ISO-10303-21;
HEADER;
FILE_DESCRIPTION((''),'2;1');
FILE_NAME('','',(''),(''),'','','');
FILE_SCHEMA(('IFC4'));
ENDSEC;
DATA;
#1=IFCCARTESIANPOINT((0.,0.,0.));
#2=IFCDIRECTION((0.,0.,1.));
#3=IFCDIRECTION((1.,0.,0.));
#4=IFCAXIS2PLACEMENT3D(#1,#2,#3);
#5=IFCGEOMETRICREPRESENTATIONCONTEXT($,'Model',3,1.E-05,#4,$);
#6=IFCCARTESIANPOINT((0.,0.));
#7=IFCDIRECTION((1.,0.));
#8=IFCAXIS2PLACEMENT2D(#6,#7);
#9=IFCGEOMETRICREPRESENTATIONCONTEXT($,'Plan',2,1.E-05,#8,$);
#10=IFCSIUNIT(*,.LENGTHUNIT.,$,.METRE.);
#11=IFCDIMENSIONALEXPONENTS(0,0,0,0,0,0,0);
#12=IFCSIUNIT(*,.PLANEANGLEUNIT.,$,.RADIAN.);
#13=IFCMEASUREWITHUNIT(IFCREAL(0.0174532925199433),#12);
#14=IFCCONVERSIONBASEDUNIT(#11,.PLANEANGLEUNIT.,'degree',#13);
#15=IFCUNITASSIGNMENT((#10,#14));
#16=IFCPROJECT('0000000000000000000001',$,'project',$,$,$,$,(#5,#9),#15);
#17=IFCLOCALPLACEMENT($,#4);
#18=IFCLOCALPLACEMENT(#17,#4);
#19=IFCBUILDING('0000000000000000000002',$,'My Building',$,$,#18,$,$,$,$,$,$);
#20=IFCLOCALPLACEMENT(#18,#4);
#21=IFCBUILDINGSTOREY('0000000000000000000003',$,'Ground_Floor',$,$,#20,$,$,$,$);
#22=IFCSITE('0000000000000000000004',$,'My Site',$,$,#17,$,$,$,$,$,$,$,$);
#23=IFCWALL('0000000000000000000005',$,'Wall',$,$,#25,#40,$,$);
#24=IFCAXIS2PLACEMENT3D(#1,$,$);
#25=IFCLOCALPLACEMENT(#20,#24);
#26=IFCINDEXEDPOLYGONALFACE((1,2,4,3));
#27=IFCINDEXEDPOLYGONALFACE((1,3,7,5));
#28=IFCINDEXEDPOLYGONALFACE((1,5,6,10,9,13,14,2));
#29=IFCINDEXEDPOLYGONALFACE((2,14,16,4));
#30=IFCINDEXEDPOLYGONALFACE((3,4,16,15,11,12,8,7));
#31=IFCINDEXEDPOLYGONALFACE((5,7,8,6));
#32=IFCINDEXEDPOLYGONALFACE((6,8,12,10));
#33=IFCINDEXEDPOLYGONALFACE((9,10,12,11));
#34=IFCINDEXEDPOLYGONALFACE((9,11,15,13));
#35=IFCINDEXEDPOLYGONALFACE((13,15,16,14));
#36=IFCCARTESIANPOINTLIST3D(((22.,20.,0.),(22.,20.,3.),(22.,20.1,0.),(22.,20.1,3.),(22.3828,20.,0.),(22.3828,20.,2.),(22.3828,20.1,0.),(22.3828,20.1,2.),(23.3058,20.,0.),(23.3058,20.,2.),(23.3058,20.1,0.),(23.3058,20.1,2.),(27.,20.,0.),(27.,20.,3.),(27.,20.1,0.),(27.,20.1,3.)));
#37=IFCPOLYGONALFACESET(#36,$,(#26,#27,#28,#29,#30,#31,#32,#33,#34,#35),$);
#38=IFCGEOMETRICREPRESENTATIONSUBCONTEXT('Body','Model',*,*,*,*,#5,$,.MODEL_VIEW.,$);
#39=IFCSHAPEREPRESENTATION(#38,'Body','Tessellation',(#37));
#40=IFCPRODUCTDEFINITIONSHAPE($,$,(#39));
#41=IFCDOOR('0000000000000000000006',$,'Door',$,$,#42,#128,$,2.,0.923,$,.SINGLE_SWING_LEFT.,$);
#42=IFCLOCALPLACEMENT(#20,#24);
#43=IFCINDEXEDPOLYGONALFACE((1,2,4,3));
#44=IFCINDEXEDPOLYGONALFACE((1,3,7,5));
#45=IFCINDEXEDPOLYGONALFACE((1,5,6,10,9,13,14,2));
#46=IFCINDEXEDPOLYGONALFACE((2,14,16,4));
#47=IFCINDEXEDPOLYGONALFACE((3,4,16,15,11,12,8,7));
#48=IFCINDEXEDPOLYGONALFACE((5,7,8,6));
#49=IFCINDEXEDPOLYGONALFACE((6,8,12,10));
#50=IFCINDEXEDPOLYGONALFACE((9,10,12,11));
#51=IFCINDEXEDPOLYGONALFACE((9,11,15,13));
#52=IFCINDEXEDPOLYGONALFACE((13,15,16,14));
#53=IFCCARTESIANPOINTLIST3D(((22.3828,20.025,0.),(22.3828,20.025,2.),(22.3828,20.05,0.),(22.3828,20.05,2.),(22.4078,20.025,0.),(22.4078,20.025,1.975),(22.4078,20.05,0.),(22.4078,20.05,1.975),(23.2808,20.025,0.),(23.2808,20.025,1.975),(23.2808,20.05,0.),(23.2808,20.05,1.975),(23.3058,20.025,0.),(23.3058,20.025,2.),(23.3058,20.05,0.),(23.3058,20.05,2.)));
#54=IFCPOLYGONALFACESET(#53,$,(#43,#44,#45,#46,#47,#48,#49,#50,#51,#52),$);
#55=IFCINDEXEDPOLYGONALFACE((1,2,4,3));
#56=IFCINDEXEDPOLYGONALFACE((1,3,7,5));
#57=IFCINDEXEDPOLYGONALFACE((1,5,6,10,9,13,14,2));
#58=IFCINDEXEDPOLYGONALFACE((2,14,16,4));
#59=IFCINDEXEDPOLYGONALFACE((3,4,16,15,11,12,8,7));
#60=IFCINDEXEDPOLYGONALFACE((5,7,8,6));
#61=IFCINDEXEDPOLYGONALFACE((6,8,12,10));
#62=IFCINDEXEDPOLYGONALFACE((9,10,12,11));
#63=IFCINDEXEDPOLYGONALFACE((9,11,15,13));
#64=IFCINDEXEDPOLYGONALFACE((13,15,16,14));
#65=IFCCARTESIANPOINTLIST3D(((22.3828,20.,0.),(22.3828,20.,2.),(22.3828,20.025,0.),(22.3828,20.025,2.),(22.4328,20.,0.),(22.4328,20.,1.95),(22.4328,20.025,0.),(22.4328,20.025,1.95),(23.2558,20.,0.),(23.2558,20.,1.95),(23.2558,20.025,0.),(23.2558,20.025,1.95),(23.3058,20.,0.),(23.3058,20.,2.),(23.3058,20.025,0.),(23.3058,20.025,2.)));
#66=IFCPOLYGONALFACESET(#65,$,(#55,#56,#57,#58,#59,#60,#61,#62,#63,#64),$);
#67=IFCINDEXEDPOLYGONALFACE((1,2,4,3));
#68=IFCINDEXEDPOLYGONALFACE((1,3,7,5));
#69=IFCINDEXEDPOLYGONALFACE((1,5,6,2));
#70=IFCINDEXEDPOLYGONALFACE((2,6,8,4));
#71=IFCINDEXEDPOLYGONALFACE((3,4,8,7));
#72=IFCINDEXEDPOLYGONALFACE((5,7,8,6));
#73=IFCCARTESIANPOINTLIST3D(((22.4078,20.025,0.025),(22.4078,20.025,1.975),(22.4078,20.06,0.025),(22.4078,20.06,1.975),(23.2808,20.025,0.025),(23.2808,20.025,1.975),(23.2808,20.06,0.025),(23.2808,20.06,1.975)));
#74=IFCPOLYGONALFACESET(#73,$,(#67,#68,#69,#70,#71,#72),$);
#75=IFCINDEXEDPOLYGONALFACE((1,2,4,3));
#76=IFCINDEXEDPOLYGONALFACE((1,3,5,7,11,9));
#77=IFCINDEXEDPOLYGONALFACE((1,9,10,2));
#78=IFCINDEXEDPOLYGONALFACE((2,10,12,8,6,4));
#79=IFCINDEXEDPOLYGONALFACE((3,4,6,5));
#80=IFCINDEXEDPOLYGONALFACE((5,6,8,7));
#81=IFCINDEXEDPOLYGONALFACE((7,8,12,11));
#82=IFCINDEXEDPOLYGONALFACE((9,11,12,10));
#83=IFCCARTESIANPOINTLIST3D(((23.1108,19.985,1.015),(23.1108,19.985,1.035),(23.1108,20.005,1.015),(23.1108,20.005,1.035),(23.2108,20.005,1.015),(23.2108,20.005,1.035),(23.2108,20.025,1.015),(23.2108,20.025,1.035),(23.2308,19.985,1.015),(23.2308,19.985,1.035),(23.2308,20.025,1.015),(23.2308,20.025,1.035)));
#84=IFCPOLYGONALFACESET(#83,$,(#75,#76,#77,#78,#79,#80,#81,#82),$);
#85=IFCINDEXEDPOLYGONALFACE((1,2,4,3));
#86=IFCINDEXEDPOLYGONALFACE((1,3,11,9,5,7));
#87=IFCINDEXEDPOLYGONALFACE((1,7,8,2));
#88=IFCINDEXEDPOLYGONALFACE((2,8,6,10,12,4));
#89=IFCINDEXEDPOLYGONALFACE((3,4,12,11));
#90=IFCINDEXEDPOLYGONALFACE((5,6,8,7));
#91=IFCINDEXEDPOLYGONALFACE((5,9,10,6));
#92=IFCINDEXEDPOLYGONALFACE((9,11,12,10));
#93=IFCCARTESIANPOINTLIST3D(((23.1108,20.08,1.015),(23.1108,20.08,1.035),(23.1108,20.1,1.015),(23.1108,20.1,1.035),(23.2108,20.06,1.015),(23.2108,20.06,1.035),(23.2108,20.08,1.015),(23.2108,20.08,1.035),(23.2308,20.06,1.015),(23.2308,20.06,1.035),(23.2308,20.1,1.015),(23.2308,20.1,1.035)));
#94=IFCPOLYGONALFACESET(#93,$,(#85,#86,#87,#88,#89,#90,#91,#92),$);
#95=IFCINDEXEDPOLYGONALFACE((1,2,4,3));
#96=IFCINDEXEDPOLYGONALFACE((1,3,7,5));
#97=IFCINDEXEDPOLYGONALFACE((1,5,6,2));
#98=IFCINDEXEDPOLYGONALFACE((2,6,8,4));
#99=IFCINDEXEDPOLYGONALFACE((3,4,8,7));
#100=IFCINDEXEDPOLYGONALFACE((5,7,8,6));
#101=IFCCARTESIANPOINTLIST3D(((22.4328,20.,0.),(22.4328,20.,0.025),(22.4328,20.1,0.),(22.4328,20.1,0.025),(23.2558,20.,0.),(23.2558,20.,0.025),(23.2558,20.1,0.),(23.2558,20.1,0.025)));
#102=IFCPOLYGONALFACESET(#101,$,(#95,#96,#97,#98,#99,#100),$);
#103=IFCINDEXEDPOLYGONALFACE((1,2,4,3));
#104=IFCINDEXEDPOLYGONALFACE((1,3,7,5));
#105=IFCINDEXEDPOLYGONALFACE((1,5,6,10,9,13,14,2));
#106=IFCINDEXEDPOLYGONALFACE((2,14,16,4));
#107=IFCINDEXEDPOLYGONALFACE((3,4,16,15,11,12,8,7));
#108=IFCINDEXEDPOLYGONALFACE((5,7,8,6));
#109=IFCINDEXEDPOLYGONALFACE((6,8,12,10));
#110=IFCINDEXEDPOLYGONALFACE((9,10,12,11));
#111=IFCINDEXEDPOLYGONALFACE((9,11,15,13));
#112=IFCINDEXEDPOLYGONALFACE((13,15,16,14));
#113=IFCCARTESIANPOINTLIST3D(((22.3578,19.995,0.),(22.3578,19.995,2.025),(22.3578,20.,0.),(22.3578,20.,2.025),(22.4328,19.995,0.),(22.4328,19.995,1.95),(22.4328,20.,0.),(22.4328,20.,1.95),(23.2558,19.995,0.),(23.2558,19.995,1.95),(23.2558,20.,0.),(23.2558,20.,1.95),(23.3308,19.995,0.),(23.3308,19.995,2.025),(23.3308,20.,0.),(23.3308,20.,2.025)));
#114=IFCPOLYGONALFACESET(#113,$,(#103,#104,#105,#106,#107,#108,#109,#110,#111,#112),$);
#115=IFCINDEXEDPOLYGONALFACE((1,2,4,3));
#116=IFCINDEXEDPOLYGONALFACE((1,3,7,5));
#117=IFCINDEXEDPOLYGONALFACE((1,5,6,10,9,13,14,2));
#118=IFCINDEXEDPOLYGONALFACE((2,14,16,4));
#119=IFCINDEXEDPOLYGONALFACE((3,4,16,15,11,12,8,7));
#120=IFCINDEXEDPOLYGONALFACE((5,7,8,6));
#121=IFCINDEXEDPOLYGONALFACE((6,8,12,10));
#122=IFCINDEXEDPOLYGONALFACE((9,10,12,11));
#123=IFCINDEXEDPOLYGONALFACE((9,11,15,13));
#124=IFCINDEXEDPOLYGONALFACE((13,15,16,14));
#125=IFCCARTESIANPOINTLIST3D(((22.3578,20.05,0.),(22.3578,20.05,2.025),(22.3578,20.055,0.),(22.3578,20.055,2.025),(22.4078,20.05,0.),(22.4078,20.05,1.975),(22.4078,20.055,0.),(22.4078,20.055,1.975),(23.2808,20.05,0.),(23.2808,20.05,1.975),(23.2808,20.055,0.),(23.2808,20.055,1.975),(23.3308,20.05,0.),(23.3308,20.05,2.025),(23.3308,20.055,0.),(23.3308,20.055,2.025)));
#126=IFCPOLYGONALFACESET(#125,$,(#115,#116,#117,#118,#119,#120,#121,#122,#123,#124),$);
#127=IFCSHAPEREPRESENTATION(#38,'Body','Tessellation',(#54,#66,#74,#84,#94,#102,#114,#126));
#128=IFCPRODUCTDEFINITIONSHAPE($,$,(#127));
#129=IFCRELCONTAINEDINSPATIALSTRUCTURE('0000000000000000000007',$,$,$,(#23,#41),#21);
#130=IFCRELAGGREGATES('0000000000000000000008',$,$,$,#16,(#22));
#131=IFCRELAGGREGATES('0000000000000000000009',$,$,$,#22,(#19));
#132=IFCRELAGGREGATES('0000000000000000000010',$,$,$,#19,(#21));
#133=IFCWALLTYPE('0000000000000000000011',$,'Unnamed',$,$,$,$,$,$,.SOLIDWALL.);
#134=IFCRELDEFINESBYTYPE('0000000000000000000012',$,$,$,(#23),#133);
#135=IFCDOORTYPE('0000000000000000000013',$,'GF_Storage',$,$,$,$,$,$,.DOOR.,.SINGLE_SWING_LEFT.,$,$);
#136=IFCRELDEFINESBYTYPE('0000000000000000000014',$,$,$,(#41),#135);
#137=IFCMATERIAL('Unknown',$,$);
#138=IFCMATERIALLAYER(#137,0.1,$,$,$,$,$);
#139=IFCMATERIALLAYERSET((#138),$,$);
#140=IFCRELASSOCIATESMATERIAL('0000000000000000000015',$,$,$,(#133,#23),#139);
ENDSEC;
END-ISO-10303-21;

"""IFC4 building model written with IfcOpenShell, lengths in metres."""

from ifc_helpers import new_model, entity, si_unit, converted_unit, frame, origin_with_axes, origin_2d_with_axis, place, context, subcontext, project, spatial, line, indexed_curve, outline, extrude, shape, source, transform, mapped, material, layer, layer_set, layer_usage, type_object, type_shapes, element, fill, save


model = new_model("IFC4")

# Units and contexts
model_context = context("Model", 3, precision=1e-05, world=origin_with_axes())
plan_context = context("Plan", 2, precision=1e-05, world=origin_2d_with_axis())
body_context_1 = subcontext(model_context, "Body", "Model", "MODEL_VIEW")
body_context_2 = subcontext(plan_context, "Body", "Plan", "PLAN_VIEW")
ifc_project = project(units=[si_unit("LENGTHUNIT", "METRE"), converted_unit("PLANEANGLEUNIT", "degree", entity("IfcReal", 0.0174532925199433), si_unit("PLANEANGLEUNIT", "RADIAN"), dimensions=[0, 0, 0, 0, 0, 0, 0])], contexts=[model_context, plan_context])

# Site, building, storey
site_placement = place(None, origin_with_axes())
site = spatial("IfcSite", under=ifc_project, at=site_placement, Name="My Site")
building_placement = place(site_placement, origin_with_axes())
building = spatial("IfcBuilding", under=site, at=building_placement, Name="My Building")
storey_placement = place(building_placement, origin_with_axes())
storey = spatial("IfcBuildingStorey", under=building, at=storey_placement, Name="Ground_Floor")

# Shared definitions
ifc_material = material(Name="Unknown")
ifc_layer = layer(ifc_material, 0.1)
ifc_layer_set = layer_set([ifc_layer])
wall_type = type_object("IfcWallType", Name="Unnamed", PredefinedType="SOLIDWALL", material=ifc_layer_set)

# Wall, opening, door
shared_shape_1 = source(origin_with_axes(), body_context_1, "Body", "SweptSolid", [
    extrude(outline(indexed_curve([(0.0, 0.0), (0.923, 0.0), (0.923, 2.0), (0.0, 2.0)], segments=[line(1, 2, 3, 4, 1)])), frame((0.0, -0.6, 0.0), z_axis=(0.0, -1.0, 0.0), x_axis=(1.0, 0.0, 0.0)), (0.0, 0.0, -1.0), 1.2),
])
door_type_1 = type_object("IfcDoorType", Name="GF_Storage", OperationType="SINGLE_SWING_LEFT", PredefinedType="DOOR")
shared_shape_2 = source(origin_with_axes(), body_context_1, "Body", "SweptSolid", [
    extrude(outline(indexed_curve([(0.0, 0.0), (0.0, 2.0), (0.923, 2.0), (0.923, 0.0), (0.898, 0.0), (0.898, 1.975), (0.025, 1.975), (0.025, 0.0)], segments=[line(1, 2, 3, 4, 5, 6, 7, 8, 1)])), frame((0.0, 0.025, 0.0), z_axis=(0.0, -1.0, 0.0), x_axis=(1.0, 0.0, 0.0)), (0.0, 0.0, -1.0), 0.025),
    extrude(outline(indexed_curve([(0.0, 0.0), (0.0, 2.0), (0.923, 2.0), (0.923, 0.0), (0.873, 0.0), (0.873, 1.95), (0.05, 1.95), (0.05, 0.0)], segments=[line(1, 2, 3, 4, 5, 6, 7, 8, 1)])), frame((0.0, 0.0, 0.0), z_axis=(0.0, -1.0, 0.0), x_axis=(1.0, 0.0, 0.0)), (0.0, 0.0, -1.0), 0.025),
    extrude(outline(indexed_curve([(0.0, 0.0), (0.873, 0.0), (0.873, 0.035), (0.0, 0.035)], segments=[line(1, 2, 3, 4, 1)])), frame((0.025, 0.025, 0.025), z_axis=(0.0, 0.0, 1.0), x_axis=(1.0, 0.0, 0.0)), (0.0, 0.0, 1.0), 1.95),
    extrude(outline(indexed_curve([(0.0, 0.0), (0.0, -0.04), (-0.12, -0.04), (-0.12, -0.02), (-0.02, -0.02), (-0.02, 0.0)], segments=[line(1, 2, 3, 4, 5, 6, 1)])), frame((0.848, 0.025, 1.015), z_axis=(0.0, 0.0, 1.0), x_axis=(1.0, 0.0, 0.0)), (0.0, 0.0, 1.0), 0.02),
    extrude(outline(indexed_curve([(0.0, 0.0), (0.0, 0.04), (-0.12, 0.04), (-0.12, 0.02), (-0.02, 0.02), (-0.02, 0.0)], segments=[line(1, 2, 3, 4, 5, 6, 1)])), frame((0.848, 0.06, 1.015), z_axis=(0.0, 0.0, 1.0), x_axis=(1.0, 0.0, 0.0)), (0.0, 0.0, 1.0), 0.02),
    extrude(outline(indexed_curve([(0.0, 0.0), (0.823, 0.0), (0.823, 0.1), (0.0, 0.1)], segments=[line(1, 2, 3, 4, 1)])), frame((0.05, 0.0, 0.0), z_axis=(0.0, 0.0, 1.0), x_axis=(1.0, 0.0, 0.0)), (0.0, 0.0, 1.0), 0.025),
    extrude(outline(indexed_curve([(0.0, 0.0), (0.0, 2.025), (0.973, 2.025), (0.973, 0.0), (0.898, 0.0), (0.898, 1.95), (0.075, 1.95), (0.075, 0.0)], segments=[line(1, 2, 3, 4, 5, 6, 7, 8, 1)])), frame((-0.025, -0.005, 0.0), z_axis=(0.0, -1.0, 0.0), x_axis=(1.0, 0.0, 0.0)), (0.0, 0.0, -1.0), 0.005),
    extrude(outline(indexed_curve([(0.0, 0.0), (0.0, 2.025), (0.973, 2.025), (0.973, 0.0), (0.923, 0.0), (0.923, 1.975), (0.05, 1.975), (0.05, 0.0)], segments=[line(1, 2, 3, 4, 5, 6, 7, 8, 1)])), frame((-0.025, 0.05, 0.0), z_axis=(0.0, -1.0, 0.0), x_axis=(1.0, 0.0, 0.0)), (0.0, 0.0, -1.0), 0.005),
])
shared_shape_3 = source(origin_with_axes(), body_context_2, "Body", "Curve2D", [
    entity("IfcIndexedPolyCurve", entity("IfcCartesianPointList2D", [[0.0, 0.0], [0.0, 0.05], [0.025, 0.05], [0.025, 0.025], [0.05, 0.025], [0.05, 0.0]]), [entity("IfcLineIndex", [1, 2, 3, 4, 5, 6, 1])]),
    entity("IfcIndexedPolyCurve", entity("IfcCartesianPointList2D", [[0.923, 0.0], [0.923, 0.05], [0.898, 0.05], [0.898, 0.025], [0.873, 0.025], [0.873, 0.0]]), [entity("IfcLineIndex", [1, 2, 3, 4, 5, 6, 1])]),
    entity("IfcTrimmedCurve", entity("IfcEllipse", entity("IfcAxis2Placement2D", entity("IfcCartesianPoint", [0.06, 0.05]), entity("IfcDirection", [1.0, 0.0])), 0.838, 0.873), [entity("IfcCartesianPoint", [0.898, 0.05])], [entity("IfcCartesianPoint", [0.06, 0.923])], True, "CARTESIAN"),
    entity("IfcIndexedPolyCurve", entity("IfcCartesianPointList2D", [[0.025, 0.05], [0.06, 0.05], [0.06, 0.923], [0.025, 0.923]]), [entity("IfcLineIndex", [1, 2, 3, 4, 1])]),
])
type_shapes(door_type_1, [shared_shape_2, shared_shape_3])
ifc_layer_usage_1 = layer_usage(ifc_layer_set, "AXIS2", "POSITIVE", 0.0)
wall_1_placement = place(storey_placement, frame((22.0, 20.0, 0.0), z_axis=(0.0, 0.0, 1.0), x_axis=(1.0, 0.0, 0.0)))
wall_1 = element("IfcWall", 1, at=wall_1_placement, inside=storey, type_object=wall_type, material=ifc_layer_usage_1, Name="Wall", context=body_context_1, shape_type="SweptSolid", body=[
    extrude(outline(indexed_curve([(0.0, 0.0), (0.0, 0.1), (5.0, 0.1), (5.0, 0.0)], segments=[line(1, 2, 3, 4, 1)])), origin_with_axes(), (0.0, 0.0, 1.0), 3.0),
])
opening_1_placement = place(wall_1_placement, frame((0.3828, 0.0, 0.0), z_axis=(0.0, 0.0, 1.0), x_axis=(1.0, 0.0, 0.0)))
opening_1 = element("IfcOpeningElement", 2, at=opening_1_placement, cuts=wall_1, PredefinedType="OPENING", context=body_context_1, shape_type="MappedRepresentation", body=[
    mapped(shared_shape_1, transform((0.0, 0.0, 0.0), x_axis=(1.0, 0.0, 0.0), y_axis=(0.0, 1.0, 0.0), z_axis=(0.0, 0.0, 1.0), scale=1.0)),
])
door_1_placement = place(opening_1_placement, frame((0.0, 0.0, 0.0), z_axis=(0.0, 0.0, 1.0), x_axis=(1.0, 0.0, 0.0)))
door_1 = element("IfcDoor", 3, at=door_1_placement, inside=storey, type_object=door_type_1, Name="Door", OperationType="SINGLE_SWING_LEFT", OverallHeight=2.0, OverallWidth=0.923, shapes=[
    shape(body_context_1, "Body", "MappedRepresentation", [mapped(shared_shape_2, transform((0.0, 0.0, 0.0), x_axis=(1.0, 0.0, 0.0), y_axis=(0.0, 1.0, 0.0), z_axis=(0.0, 0.0, 1.0), scale=1.0))]),
    shape(body_context_2, "Body", "MappedRepresentation", [mapped(shared_shape_3, transform((0.0, 0.0, 0.0), x_axis=(1.0, 0.0, 0.0), y_axis=(0.0, 1.0, 0.0), z_axis=(0.0, 0.0, 1.0), scale=1.0))]),
])
fill(opening_1, door_1)

save(model, "model.ifc")
